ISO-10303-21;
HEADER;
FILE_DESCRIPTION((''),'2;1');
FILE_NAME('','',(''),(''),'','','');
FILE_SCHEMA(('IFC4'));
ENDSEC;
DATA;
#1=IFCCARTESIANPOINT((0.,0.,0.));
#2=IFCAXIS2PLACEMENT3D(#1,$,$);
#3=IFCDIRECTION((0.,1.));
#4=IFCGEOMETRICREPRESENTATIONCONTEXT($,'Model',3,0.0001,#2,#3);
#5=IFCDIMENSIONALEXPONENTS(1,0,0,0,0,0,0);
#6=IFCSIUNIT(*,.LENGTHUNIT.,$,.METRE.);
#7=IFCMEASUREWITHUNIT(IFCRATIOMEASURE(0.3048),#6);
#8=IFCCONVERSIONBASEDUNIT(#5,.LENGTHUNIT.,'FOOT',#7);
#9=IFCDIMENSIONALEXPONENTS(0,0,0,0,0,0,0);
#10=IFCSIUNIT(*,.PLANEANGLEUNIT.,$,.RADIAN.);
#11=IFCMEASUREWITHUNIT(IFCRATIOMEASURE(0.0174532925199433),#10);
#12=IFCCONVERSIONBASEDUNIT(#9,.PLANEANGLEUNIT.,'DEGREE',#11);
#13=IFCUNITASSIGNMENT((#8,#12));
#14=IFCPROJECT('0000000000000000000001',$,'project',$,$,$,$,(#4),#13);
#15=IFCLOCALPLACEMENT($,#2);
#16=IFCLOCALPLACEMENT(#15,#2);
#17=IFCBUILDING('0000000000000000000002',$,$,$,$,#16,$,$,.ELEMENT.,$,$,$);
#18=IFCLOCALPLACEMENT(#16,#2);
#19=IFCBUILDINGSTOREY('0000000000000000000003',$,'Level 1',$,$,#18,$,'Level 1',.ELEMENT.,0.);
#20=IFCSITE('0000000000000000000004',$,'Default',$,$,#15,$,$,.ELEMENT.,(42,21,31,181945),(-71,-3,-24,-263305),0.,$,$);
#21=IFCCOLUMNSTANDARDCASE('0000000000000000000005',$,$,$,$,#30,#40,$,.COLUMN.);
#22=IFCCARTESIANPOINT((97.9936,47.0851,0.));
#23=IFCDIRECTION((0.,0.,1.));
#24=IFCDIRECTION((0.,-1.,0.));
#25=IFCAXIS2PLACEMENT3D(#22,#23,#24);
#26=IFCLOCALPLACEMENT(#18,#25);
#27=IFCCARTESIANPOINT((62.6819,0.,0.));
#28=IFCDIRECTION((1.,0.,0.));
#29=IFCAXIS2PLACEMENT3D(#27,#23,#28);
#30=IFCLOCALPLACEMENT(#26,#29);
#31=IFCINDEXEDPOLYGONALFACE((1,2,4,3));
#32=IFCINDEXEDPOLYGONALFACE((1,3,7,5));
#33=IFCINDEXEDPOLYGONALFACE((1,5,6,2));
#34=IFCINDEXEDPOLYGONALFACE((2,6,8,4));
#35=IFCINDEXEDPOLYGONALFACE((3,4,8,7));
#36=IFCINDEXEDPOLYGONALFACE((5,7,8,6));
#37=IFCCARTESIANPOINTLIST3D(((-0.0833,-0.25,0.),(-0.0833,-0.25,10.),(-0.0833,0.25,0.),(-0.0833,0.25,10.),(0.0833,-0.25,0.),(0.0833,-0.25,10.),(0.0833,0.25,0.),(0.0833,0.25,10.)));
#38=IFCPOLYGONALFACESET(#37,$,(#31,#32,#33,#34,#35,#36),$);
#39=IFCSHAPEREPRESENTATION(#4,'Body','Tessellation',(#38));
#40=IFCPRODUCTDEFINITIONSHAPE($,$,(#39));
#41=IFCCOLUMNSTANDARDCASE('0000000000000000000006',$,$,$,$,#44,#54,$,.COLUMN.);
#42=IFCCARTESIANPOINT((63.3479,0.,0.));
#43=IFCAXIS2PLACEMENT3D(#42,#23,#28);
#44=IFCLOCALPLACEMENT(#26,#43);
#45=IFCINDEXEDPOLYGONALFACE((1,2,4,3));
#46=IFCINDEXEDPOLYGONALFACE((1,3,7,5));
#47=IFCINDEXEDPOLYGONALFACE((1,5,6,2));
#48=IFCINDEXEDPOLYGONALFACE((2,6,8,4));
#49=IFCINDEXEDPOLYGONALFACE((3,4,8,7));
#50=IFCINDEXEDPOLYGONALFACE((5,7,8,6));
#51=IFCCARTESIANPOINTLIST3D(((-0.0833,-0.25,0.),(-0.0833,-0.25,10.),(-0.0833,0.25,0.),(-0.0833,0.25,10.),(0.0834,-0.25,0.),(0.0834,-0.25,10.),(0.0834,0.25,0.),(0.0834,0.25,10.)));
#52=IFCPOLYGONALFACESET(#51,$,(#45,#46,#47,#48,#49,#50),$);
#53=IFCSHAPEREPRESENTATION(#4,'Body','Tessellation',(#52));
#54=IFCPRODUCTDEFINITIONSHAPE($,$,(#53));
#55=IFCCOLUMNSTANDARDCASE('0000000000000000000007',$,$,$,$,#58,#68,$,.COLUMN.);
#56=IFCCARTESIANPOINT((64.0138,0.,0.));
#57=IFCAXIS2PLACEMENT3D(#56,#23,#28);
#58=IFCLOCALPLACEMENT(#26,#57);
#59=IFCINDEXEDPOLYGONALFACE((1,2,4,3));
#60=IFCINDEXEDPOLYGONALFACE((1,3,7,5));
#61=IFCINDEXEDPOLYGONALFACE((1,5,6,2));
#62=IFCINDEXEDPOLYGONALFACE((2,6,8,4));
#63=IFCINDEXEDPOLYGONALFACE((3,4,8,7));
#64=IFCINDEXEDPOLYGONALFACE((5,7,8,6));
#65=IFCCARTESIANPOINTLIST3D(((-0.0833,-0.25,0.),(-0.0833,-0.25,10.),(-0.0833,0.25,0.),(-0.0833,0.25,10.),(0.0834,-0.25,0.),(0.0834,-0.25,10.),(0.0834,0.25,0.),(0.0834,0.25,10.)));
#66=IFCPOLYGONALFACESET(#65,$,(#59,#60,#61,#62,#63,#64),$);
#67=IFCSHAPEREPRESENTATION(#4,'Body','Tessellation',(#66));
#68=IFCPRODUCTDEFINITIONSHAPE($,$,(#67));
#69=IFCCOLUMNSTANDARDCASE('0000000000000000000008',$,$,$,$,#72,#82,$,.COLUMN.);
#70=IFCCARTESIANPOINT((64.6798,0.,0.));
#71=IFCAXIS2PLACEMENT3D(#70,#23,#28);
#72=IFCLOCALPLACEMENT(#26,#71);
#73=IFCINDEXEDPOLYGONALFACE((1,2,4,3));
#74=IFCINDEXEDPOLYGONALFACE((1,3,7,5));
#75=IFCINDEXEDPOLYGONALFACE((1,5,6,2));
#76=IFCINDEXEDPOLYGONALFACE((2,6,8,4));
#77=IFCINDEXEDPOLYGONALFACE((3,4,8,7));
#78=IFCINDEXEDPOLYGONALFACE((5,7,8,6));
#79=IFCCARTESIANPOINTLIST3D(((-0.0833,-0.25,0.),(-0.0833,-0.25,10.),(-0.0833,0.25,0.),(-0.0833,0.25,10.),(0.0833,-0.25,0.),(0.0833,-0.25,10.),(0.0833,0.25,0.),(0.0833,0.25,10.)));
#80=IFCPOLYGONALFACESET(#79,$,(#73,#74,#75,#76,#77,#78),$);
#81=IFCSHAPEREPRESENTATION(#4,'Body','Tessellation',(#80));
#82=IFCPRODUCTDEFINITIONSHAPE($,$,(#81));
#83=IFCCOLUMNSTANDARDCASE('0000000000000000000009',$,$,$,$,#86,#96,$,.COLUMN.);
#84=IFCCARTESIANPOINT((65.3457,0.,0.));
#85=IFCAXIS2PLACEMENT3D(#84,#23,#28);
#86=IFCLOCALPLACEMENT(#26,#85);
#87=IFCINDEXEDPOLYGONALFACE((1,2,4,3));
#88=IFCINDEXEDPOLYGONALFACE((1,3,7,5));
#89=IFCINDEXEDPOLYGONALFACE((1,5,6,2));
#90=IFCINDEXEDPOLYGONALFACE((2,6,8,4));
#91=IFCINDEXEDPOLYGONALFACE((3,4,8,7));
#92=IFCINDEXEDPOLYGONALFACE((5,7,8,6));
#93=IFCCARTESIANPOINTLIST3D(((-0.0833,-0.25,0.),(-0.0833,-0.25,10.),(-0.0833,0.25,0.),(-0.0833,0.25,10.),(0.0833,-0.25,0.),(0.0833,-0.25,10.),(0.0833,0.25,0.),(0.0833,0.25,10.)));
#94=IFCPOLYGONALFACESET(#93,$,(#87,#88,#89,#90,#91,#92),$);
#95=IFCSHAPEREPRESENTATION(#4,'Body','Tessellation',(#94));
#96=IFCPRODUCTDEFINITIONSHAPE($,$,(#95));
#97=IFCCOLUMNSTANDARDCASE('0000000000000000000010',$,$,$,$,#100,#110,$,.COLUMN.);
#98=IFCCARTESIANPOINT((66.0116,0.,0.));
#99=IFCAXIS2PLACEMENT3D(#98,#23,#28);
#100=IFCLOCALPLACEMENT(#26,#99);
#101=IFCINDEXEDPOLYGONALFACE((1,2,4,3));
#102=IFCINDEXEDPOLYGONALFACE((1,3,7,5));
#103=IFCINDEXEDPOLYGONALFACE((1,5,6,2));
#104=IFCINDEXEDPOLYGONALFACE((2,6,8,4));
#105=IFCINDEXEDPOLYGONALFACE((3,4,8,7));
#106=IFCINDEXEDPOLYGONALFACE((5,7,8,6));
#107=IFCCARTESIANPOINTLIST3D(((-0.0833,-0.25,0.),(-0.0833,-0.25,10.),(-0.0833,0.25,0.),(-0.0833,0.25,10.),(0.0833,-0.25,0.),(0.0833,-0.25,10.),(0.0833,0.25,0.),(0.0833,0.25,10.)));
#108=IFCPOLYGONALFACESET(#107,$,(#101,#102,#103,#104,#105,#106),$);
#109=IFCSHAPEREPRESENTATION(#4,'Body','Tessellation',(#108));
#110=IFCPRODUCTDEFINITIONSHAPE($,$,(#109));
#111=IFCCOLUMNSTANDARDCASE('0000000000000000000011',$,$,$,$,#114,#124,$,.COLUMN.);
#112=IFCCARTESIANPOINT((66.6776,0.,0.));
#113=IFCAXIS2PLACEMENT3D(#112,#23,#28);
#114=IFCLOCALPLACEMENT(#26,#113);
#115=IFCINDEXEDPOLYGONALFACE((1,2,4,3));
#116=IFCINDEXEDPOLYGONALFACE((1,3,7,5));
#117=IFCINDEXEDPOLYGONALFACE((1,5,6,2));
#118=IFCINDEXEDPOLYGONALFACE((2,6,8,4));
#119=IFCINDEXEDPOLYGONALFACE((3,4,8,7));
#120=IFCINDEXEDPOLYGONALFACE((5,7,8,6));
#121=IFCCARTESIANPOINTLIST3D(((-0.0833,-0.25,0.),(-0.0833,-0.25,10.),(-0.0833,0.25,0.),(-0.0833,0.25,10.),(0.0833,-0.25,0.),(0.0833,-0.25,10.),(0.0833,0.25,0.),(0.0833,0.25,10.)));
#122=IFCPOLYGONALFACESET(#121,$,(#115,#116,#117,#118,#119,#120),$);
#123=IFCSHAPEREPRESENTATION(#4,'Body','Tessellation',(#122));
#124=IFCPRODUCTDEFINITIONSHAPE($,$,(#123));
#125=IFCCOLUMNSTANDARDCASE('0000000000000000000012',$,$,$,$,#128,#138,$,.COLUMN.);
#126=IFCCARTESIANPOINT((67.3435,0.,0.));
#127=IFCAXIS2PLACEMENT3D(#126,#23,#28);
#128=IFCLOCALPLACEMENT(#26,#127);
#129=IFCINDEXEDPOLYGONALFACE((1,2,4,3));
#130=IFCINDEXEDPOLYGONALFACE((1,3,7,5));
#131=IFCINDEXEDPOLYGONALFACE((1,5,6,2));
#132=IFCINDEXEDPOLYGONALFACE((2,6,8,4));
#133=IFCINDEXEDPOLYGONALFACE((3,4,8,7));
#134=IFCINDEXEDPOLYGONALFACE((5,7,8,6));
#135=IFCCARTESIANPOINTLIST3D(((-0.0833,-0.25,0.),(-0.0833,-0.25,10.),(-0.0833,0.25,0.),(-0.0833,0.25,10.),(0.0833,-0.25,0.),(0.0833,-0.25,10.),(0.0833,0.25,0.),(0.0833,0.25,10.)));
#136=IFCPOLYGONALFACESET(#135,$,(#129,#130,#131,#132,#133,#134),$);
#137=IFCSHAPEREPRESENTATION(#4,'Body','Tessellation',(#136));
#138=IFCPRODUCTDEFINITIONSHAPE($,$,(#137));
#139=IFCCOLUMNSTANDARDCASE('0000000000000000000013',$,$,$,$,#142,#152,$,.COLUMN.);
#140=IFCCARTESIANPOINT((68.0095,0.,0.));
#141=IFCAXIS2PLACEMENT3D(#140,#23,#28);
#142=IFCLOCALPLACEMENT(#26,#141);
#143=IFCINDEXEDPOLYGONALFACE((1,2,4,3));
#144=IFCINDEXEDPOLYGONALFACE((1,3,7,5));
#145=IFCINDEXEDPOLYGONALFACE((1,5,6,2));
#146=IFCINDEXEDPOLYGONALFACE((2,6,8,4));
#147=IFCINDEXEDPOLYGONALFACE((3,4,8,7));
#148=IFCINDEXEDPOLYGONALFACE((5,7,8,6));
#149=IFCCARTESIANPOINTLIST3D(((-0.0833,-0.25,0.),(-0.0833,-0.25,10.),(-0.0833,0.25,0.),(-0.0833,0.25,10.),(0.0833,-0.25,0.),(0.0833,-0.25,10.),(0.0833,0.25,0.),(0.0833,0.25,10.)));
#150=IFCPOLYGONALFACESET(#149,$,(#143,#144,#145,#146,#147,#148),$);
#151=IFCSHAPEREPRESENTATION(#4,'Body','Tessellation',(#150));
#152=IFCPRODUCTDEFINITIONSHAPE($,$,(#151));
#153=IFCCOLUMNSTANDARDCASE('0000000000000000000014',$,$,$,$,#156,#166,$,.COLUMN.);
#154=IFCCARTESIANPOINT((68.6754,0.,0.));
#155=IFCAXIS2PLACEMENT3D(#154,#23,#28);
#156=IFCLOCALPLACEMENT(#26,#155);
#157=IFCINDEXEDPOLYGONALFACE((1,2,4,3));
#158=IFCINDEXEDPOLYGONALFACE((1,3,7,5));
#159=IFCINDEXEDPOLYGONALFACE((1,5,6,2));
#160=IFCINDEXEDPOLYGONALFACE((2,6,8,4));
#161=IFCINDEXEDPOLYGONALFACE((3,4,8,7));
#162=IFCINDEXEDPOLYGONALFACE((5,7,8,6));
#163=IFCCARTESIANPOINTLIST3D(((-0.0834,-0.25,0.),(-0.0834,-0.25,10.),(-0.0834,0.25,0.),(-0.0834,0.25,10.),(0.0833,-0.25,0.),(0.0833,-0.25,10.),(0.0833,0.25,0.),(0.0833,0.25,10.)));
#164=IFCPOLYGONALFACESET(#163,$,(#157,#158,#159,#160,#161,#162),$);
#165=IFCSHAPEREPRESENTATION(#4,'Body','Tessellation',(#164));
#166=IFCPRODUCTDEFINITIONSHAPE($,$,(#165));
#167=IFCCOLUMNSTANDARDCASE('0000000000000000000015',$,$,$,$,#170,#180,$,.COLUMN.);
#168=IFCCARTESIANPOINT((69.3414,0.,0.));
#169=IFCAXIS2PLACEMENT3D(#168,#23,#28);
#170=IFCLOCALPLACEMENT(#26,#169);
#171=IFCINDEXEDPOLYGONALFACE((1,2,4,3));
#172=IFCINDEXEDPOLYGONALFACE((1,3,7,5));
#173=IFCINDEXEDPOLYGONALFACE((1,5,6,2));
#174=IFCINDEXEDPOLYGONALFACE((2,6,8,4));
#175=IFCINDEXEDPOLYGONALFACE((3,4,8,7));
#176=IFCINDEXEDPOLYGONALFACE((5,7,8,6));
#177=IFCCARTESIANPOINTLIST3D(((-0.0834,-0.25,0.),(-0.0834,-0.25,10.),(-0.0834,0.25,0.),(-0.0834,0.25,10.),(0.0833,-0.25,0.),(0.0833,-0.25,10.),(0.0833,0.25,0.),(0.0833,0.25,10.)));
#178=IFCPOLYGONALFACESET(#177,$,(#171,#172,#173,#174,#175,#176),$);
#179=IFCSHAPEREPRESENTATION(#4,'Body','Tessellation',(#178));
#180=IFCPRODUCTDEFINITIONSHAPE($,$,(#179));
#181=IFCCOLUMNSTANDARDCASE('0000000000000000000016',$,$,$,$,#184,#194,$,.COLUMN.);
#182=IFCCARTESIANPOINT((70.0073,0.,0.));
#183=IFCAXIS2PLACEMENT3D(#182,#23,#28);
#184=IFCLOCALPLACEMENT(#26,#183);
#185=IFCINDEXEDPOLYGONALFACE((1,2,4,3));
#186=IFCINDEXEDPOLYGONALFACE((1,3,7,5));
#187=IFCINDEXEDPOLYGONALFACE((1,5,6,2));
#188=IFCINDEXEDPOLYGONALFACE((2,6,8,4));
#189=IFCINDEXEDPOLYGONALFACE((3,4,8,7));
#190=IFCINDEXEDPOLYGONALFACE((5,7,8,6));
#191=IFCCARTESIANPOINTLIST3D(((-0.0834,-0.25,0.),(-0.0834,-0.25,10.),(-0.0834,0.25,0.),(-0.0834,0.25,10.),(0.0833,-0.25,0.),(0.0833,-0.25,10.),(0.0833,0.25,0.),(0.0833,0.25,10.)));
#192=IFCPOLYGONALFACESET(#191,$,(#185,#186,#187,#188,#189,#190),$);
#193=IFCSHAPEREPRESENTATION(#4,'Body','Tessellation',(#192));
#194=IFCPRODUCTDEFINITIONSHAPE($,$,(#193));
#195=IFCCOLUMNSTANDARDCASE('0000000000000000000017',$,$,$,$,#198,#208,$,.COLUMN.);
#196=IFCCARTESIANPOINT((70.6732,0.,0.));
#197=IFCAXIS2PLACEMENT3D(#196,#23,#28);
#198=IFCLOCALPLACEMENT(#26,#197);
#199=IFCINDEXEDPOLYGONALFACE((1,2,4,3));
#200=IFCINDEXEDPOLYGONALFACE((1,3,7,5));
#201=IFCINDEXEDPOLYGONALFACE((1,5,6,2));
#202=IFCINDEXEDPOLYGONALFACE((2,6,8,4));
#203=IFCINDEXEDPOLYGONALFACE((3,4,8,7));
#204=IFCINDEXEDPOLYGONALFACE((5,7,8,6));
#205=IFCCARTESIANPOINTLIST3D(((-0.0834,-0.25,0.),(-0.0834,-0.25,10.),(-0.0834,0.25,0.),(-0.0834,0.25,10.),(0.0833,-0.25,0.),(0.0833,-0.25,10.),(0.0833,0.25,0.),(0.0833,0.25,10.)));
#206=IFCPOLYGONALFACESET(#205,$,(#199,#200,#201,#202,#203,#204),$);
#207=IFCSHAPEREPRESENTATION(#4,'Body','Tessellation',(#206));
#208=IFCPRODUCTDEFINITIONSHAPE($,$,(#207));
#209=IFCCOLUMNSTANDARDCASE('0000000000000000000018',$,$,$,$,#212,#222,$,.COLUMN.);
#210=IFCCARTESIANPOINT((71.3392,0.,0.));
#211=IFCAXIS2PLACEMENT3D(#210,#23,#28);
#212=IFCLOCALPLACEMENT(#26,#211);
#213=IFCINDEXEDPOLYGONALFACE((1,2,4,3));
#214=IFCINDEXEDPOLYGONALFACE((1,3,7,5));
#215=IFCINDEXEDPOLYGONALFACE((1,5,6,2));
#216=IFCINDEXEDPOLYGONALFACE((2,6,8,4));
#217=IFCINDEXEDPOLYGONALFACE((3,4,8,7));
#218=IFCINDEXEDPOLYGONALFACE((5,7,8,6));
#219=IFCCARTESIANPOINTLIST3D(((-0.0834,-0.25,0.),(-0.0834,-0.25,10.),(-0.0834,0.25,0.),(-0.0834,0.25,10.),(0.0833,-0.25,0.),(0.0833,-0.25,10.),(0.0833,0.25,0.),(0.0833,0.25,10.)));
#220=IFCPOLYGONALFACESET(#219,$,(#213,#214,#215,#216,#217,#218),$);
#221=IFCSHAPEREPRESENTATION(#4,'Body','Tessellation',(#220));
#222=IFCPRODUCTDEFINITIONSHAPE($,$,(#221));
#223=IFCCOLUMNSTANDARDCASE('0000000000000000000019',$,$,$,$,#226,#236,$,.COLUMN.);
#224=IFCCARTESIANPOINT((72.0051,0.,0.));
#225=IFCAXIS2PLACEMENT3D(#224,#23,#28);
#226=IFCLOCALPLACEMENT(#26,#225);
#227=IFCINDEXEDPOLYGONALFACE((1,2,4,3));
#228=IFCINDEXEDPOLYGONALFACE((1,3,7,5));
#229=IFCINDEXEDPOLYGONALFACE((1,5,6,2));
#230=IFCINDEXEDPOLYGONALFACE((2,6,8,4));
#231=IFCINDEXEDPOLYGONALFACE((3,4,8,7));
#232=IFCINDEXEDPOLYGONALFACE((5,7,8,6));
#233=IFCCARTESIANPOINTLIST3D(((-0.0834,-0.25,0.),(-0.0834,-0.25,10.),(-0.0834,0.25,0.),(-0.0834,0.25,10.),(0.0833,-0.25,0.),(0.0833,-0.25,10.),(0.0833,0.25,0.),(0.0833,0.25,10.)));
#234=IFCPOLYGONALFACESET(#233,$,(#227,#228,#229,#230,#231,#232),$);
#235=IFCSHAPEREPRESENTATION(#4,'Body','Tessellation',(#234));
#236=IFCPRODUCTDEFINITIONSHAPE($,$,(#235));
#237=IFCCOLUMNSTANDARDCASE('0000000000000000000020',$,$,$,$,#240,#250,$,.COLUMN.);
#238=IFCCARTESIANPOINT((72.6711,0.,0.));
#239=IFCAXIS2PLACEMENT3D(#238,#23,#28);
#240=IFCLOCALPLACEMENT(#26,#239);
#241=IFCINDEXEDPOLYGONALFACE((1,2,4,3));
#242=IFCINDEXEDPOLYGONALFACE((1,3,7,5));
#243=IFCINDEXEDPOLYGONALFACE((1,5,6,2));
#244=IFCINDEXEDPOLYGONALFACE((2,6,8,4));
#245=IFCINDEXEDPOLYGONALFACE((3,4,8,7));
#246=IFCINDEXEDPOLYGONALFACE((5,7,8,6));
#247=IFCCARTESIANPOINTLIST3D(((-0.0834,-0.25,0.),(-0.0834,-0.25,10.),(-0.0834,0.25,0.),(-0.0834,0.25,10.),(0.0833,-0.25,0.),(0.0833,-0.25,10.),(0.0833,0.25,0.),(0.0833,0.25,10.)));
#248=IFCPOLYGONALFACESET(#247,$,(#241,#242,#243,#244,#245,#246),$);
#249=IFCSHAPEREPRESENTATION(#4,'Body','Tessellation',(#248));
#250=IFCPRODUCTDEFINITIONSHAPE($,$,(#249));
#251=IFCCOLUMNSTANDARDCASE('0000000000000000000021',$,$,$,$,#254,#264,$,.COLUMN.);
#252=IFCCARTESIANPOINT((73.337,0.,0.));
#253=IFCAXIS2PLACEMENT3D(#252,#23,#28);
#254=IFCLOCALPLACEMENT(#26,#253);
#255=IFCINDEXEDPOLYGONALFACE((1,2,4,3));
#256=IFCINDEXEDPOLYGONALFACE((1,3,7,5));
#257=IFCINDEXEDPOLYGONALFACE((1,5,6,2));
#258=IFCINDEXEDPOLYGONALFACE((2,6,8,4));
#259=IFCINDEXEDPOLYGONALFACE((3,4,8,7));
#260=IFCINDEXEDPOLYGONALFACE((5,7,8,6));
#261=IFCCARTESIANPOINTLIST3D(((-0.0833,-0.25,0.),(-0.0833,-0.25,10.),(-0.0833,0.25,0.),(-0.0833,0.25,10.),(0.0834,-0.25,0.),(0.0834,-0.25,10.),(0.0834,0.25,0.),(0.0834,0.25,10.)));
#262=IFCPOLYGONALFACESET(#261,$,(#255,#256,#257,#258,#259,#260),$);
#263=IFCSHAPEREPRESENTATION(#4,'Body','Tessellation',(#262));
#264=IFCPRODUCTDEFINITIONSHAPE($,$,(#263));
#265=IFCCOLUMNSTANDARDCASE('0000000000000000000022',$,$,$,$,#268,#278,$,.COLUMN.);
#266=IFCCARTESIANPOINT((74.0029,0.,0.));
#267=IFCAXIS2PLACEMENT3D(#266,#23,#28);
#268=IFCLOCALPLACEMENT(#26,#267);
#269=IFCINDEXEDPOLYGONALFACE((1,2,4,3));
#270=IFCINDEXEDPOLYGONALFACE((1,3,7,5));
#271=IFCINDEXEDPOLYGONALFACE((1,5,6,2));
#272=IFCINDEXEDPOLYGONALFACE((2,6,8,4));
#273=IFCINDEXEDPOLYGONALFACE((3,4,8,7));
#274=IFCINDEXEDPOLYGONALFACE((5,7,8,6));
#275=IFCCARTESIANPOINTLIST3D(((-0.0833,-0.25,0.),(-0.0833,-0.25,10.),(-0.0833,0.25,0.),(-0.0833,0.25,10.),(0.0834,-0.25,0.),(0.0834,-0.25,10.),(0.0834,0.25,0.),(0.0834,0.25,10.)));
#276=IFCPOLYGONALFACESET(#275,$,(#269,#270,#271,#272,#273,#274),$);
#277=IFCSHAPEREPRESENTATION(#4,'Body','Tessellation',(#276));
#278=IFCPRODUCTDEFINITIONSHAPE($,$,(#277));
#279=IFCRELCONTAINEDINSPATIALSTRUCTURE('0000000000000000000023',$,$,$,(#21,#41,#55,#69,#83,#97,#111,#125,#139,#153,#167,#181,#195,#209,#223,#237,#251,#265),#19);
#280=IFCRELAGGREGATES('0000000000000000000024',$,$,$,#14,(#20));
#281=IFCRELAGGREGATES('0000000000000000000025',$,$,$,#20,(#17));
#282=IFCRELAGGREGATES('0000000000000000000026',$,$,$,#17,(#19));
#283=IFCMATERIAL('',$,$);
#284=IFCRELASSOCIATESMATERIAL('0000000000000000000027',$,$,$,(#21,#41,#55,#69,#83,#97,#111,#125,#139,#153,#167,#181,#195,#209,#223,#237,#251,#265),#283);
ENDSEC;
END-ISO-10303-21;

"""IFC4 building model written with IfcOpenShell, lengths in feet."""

from ifc_helpers import new_model, entity, si_unit, converted_unit, direction, frame, origin, place, context, project, spatial, rectangle, extrude, material, element, save


model = new_model("IFC4")

# Units and contexts
model_context = context("Model", 3, precision=0.0001, world=origin(), true_north=direction((0.0, 1.0)))
ifc_project = project(units=[converted_unit("LENGTHUNIT", "FOOT", entity("IfcRatioMeasure", 0.3048), si_unit("LENGTHUNIT", "METRE"), dimensions=[1, 0, 0, 0, 0, 0, 0]), converted_unit("PLANEANGLEUNIT", "DEGREE", entity("IfcRatioMeasure", 0.0174532925199433), si_unit("PLANEANGLEUNIT", "RADIAN"), dimensions=[0, 0, 0, 0, 0, 0, 0])], contexts=[model_context])

# Site, building, storey
site_placement = place(None, origin())
site = spatial("IfcSite", under=ifc_project, at=site_placement, Name="Default", CompositionType="ELEMENT", RefLatitude=(42, 21, 31, 181945), RefLongitude=(-71, -3, -24, -263305), RefElevation=0.0)
building_placement = place(site_placement, origin())
building = spatial("IfcBuilding", under=site, at=building_placement, CompositionType="ELEMENT")
storey_placement = place(building_placement, origin())
storey = spatial("IfcBuildingStorey", under=building, at=storey_placement, Name="Level 1", LongName="Level 1", CompositionType="ELEMENT", Elevation=0.0)

# Columns
ifc_material_1 = material(Name="")
placement = place(storey_placement, frame((97.9936, 47.0851, 0.0), z_axis=(0.0, 0.0, 1.0), x_axis=(0.0, -1.0, 0.0)))
for number, where, z_axis, x_axis in (
    (1, (62.6819, 0.0, 0.0), (0.0, 0.0, 1.0), (1.0, 0.0, 0.0)),
    (2, (63.3479, 0.0, 0.0), (0.0, 0.0, 1.0), (1.0, 0.0, 0.0)),
    (3, (64.0138, 0.0, 0.0), (0.0, 0.0, 1.0), (1.0, 0.0, 0.0)),
    (4, (64.6798, 0.0, 0.0), (0.0, 0.0, 1.0), (1.0, 0.0, 0.0)),
    (5, (65.3457, 0.0, 0.0), (0.0, 0.0, 1.0), (1.0, 0.0, 0.0)),
    (6, (66.0116, 0.0, 0.0), (0.0, 0.0, 1.0), (1.0, 0.0, 0.0)),
    (7, (66.6776, 0.0, 0.0), (0.0, 0.0, 1.0), (1.0, 0.0, 0.0)),
    (8, (67.3435, 0.0, 0.0), (0.0, 0.0, 1.0), (1.0, 0.0, 0.0)),
    (9, (68.0095, 0.0, 0.0), (0.0, 0.0, 1.0), (1.0, 0.0, 0.0)),
    (10, (68.6754, 0.0, 0.0), (0.0, 0.0, 1.0), (1.0, 0.0, 0.0)),
    (11, (69.3414, 0.0, 0.0), (0.0, 0.0, 1.0), (1.0, 0.0, 0.0)),
    (12, (70.0073, 0.0, 0.0), (0.0, 0.0, 1.0), (1.0, 0.0, 0.0)),
    (13, (70.6732, 0.0, 0.0), (0.0, 0.0, 1.0), (1.0, 0.0, 0.0)),
    (14, (71.3392, 0.0, 0.0), (0.0, 0.0, 1.0), (1.0, 0.0, 0.0)),
    (15, (72.0051, 0.0, 0.0), (0.0, 0.0, 1.0), (1.0, 0.0, 0.0)),
    (16, (72.6711, 0.0, 0.0), (0.0, 0.0, 1.0), (1.0, 0.0, 0.0)),
    (17, (73.337, 0.0, 0.0), (0.0, 0.0, 1.0), (1.0, 0.0, 0.0)),
    (18, (74.0029, 0.0, 0.0), (0.0, 0.0, 1.0), (1.0, 0.0, 0.0)),
):
    element("IfcColumnStandardCase", number, at=place(placement, frame(where, z_axis=z_axis, x_axis=x_axis)), inside=storey, material=ifc_material_1, PredefinedType="COLUMN", context=model_context, shape_type="SweptSolid", body=[
        extrude(rectangle(XDim=0.1667, YDim=0.5), origin(), (0.0, 0.0, 1.0), 10.0),
    ])

save(model, "model.ifc")
